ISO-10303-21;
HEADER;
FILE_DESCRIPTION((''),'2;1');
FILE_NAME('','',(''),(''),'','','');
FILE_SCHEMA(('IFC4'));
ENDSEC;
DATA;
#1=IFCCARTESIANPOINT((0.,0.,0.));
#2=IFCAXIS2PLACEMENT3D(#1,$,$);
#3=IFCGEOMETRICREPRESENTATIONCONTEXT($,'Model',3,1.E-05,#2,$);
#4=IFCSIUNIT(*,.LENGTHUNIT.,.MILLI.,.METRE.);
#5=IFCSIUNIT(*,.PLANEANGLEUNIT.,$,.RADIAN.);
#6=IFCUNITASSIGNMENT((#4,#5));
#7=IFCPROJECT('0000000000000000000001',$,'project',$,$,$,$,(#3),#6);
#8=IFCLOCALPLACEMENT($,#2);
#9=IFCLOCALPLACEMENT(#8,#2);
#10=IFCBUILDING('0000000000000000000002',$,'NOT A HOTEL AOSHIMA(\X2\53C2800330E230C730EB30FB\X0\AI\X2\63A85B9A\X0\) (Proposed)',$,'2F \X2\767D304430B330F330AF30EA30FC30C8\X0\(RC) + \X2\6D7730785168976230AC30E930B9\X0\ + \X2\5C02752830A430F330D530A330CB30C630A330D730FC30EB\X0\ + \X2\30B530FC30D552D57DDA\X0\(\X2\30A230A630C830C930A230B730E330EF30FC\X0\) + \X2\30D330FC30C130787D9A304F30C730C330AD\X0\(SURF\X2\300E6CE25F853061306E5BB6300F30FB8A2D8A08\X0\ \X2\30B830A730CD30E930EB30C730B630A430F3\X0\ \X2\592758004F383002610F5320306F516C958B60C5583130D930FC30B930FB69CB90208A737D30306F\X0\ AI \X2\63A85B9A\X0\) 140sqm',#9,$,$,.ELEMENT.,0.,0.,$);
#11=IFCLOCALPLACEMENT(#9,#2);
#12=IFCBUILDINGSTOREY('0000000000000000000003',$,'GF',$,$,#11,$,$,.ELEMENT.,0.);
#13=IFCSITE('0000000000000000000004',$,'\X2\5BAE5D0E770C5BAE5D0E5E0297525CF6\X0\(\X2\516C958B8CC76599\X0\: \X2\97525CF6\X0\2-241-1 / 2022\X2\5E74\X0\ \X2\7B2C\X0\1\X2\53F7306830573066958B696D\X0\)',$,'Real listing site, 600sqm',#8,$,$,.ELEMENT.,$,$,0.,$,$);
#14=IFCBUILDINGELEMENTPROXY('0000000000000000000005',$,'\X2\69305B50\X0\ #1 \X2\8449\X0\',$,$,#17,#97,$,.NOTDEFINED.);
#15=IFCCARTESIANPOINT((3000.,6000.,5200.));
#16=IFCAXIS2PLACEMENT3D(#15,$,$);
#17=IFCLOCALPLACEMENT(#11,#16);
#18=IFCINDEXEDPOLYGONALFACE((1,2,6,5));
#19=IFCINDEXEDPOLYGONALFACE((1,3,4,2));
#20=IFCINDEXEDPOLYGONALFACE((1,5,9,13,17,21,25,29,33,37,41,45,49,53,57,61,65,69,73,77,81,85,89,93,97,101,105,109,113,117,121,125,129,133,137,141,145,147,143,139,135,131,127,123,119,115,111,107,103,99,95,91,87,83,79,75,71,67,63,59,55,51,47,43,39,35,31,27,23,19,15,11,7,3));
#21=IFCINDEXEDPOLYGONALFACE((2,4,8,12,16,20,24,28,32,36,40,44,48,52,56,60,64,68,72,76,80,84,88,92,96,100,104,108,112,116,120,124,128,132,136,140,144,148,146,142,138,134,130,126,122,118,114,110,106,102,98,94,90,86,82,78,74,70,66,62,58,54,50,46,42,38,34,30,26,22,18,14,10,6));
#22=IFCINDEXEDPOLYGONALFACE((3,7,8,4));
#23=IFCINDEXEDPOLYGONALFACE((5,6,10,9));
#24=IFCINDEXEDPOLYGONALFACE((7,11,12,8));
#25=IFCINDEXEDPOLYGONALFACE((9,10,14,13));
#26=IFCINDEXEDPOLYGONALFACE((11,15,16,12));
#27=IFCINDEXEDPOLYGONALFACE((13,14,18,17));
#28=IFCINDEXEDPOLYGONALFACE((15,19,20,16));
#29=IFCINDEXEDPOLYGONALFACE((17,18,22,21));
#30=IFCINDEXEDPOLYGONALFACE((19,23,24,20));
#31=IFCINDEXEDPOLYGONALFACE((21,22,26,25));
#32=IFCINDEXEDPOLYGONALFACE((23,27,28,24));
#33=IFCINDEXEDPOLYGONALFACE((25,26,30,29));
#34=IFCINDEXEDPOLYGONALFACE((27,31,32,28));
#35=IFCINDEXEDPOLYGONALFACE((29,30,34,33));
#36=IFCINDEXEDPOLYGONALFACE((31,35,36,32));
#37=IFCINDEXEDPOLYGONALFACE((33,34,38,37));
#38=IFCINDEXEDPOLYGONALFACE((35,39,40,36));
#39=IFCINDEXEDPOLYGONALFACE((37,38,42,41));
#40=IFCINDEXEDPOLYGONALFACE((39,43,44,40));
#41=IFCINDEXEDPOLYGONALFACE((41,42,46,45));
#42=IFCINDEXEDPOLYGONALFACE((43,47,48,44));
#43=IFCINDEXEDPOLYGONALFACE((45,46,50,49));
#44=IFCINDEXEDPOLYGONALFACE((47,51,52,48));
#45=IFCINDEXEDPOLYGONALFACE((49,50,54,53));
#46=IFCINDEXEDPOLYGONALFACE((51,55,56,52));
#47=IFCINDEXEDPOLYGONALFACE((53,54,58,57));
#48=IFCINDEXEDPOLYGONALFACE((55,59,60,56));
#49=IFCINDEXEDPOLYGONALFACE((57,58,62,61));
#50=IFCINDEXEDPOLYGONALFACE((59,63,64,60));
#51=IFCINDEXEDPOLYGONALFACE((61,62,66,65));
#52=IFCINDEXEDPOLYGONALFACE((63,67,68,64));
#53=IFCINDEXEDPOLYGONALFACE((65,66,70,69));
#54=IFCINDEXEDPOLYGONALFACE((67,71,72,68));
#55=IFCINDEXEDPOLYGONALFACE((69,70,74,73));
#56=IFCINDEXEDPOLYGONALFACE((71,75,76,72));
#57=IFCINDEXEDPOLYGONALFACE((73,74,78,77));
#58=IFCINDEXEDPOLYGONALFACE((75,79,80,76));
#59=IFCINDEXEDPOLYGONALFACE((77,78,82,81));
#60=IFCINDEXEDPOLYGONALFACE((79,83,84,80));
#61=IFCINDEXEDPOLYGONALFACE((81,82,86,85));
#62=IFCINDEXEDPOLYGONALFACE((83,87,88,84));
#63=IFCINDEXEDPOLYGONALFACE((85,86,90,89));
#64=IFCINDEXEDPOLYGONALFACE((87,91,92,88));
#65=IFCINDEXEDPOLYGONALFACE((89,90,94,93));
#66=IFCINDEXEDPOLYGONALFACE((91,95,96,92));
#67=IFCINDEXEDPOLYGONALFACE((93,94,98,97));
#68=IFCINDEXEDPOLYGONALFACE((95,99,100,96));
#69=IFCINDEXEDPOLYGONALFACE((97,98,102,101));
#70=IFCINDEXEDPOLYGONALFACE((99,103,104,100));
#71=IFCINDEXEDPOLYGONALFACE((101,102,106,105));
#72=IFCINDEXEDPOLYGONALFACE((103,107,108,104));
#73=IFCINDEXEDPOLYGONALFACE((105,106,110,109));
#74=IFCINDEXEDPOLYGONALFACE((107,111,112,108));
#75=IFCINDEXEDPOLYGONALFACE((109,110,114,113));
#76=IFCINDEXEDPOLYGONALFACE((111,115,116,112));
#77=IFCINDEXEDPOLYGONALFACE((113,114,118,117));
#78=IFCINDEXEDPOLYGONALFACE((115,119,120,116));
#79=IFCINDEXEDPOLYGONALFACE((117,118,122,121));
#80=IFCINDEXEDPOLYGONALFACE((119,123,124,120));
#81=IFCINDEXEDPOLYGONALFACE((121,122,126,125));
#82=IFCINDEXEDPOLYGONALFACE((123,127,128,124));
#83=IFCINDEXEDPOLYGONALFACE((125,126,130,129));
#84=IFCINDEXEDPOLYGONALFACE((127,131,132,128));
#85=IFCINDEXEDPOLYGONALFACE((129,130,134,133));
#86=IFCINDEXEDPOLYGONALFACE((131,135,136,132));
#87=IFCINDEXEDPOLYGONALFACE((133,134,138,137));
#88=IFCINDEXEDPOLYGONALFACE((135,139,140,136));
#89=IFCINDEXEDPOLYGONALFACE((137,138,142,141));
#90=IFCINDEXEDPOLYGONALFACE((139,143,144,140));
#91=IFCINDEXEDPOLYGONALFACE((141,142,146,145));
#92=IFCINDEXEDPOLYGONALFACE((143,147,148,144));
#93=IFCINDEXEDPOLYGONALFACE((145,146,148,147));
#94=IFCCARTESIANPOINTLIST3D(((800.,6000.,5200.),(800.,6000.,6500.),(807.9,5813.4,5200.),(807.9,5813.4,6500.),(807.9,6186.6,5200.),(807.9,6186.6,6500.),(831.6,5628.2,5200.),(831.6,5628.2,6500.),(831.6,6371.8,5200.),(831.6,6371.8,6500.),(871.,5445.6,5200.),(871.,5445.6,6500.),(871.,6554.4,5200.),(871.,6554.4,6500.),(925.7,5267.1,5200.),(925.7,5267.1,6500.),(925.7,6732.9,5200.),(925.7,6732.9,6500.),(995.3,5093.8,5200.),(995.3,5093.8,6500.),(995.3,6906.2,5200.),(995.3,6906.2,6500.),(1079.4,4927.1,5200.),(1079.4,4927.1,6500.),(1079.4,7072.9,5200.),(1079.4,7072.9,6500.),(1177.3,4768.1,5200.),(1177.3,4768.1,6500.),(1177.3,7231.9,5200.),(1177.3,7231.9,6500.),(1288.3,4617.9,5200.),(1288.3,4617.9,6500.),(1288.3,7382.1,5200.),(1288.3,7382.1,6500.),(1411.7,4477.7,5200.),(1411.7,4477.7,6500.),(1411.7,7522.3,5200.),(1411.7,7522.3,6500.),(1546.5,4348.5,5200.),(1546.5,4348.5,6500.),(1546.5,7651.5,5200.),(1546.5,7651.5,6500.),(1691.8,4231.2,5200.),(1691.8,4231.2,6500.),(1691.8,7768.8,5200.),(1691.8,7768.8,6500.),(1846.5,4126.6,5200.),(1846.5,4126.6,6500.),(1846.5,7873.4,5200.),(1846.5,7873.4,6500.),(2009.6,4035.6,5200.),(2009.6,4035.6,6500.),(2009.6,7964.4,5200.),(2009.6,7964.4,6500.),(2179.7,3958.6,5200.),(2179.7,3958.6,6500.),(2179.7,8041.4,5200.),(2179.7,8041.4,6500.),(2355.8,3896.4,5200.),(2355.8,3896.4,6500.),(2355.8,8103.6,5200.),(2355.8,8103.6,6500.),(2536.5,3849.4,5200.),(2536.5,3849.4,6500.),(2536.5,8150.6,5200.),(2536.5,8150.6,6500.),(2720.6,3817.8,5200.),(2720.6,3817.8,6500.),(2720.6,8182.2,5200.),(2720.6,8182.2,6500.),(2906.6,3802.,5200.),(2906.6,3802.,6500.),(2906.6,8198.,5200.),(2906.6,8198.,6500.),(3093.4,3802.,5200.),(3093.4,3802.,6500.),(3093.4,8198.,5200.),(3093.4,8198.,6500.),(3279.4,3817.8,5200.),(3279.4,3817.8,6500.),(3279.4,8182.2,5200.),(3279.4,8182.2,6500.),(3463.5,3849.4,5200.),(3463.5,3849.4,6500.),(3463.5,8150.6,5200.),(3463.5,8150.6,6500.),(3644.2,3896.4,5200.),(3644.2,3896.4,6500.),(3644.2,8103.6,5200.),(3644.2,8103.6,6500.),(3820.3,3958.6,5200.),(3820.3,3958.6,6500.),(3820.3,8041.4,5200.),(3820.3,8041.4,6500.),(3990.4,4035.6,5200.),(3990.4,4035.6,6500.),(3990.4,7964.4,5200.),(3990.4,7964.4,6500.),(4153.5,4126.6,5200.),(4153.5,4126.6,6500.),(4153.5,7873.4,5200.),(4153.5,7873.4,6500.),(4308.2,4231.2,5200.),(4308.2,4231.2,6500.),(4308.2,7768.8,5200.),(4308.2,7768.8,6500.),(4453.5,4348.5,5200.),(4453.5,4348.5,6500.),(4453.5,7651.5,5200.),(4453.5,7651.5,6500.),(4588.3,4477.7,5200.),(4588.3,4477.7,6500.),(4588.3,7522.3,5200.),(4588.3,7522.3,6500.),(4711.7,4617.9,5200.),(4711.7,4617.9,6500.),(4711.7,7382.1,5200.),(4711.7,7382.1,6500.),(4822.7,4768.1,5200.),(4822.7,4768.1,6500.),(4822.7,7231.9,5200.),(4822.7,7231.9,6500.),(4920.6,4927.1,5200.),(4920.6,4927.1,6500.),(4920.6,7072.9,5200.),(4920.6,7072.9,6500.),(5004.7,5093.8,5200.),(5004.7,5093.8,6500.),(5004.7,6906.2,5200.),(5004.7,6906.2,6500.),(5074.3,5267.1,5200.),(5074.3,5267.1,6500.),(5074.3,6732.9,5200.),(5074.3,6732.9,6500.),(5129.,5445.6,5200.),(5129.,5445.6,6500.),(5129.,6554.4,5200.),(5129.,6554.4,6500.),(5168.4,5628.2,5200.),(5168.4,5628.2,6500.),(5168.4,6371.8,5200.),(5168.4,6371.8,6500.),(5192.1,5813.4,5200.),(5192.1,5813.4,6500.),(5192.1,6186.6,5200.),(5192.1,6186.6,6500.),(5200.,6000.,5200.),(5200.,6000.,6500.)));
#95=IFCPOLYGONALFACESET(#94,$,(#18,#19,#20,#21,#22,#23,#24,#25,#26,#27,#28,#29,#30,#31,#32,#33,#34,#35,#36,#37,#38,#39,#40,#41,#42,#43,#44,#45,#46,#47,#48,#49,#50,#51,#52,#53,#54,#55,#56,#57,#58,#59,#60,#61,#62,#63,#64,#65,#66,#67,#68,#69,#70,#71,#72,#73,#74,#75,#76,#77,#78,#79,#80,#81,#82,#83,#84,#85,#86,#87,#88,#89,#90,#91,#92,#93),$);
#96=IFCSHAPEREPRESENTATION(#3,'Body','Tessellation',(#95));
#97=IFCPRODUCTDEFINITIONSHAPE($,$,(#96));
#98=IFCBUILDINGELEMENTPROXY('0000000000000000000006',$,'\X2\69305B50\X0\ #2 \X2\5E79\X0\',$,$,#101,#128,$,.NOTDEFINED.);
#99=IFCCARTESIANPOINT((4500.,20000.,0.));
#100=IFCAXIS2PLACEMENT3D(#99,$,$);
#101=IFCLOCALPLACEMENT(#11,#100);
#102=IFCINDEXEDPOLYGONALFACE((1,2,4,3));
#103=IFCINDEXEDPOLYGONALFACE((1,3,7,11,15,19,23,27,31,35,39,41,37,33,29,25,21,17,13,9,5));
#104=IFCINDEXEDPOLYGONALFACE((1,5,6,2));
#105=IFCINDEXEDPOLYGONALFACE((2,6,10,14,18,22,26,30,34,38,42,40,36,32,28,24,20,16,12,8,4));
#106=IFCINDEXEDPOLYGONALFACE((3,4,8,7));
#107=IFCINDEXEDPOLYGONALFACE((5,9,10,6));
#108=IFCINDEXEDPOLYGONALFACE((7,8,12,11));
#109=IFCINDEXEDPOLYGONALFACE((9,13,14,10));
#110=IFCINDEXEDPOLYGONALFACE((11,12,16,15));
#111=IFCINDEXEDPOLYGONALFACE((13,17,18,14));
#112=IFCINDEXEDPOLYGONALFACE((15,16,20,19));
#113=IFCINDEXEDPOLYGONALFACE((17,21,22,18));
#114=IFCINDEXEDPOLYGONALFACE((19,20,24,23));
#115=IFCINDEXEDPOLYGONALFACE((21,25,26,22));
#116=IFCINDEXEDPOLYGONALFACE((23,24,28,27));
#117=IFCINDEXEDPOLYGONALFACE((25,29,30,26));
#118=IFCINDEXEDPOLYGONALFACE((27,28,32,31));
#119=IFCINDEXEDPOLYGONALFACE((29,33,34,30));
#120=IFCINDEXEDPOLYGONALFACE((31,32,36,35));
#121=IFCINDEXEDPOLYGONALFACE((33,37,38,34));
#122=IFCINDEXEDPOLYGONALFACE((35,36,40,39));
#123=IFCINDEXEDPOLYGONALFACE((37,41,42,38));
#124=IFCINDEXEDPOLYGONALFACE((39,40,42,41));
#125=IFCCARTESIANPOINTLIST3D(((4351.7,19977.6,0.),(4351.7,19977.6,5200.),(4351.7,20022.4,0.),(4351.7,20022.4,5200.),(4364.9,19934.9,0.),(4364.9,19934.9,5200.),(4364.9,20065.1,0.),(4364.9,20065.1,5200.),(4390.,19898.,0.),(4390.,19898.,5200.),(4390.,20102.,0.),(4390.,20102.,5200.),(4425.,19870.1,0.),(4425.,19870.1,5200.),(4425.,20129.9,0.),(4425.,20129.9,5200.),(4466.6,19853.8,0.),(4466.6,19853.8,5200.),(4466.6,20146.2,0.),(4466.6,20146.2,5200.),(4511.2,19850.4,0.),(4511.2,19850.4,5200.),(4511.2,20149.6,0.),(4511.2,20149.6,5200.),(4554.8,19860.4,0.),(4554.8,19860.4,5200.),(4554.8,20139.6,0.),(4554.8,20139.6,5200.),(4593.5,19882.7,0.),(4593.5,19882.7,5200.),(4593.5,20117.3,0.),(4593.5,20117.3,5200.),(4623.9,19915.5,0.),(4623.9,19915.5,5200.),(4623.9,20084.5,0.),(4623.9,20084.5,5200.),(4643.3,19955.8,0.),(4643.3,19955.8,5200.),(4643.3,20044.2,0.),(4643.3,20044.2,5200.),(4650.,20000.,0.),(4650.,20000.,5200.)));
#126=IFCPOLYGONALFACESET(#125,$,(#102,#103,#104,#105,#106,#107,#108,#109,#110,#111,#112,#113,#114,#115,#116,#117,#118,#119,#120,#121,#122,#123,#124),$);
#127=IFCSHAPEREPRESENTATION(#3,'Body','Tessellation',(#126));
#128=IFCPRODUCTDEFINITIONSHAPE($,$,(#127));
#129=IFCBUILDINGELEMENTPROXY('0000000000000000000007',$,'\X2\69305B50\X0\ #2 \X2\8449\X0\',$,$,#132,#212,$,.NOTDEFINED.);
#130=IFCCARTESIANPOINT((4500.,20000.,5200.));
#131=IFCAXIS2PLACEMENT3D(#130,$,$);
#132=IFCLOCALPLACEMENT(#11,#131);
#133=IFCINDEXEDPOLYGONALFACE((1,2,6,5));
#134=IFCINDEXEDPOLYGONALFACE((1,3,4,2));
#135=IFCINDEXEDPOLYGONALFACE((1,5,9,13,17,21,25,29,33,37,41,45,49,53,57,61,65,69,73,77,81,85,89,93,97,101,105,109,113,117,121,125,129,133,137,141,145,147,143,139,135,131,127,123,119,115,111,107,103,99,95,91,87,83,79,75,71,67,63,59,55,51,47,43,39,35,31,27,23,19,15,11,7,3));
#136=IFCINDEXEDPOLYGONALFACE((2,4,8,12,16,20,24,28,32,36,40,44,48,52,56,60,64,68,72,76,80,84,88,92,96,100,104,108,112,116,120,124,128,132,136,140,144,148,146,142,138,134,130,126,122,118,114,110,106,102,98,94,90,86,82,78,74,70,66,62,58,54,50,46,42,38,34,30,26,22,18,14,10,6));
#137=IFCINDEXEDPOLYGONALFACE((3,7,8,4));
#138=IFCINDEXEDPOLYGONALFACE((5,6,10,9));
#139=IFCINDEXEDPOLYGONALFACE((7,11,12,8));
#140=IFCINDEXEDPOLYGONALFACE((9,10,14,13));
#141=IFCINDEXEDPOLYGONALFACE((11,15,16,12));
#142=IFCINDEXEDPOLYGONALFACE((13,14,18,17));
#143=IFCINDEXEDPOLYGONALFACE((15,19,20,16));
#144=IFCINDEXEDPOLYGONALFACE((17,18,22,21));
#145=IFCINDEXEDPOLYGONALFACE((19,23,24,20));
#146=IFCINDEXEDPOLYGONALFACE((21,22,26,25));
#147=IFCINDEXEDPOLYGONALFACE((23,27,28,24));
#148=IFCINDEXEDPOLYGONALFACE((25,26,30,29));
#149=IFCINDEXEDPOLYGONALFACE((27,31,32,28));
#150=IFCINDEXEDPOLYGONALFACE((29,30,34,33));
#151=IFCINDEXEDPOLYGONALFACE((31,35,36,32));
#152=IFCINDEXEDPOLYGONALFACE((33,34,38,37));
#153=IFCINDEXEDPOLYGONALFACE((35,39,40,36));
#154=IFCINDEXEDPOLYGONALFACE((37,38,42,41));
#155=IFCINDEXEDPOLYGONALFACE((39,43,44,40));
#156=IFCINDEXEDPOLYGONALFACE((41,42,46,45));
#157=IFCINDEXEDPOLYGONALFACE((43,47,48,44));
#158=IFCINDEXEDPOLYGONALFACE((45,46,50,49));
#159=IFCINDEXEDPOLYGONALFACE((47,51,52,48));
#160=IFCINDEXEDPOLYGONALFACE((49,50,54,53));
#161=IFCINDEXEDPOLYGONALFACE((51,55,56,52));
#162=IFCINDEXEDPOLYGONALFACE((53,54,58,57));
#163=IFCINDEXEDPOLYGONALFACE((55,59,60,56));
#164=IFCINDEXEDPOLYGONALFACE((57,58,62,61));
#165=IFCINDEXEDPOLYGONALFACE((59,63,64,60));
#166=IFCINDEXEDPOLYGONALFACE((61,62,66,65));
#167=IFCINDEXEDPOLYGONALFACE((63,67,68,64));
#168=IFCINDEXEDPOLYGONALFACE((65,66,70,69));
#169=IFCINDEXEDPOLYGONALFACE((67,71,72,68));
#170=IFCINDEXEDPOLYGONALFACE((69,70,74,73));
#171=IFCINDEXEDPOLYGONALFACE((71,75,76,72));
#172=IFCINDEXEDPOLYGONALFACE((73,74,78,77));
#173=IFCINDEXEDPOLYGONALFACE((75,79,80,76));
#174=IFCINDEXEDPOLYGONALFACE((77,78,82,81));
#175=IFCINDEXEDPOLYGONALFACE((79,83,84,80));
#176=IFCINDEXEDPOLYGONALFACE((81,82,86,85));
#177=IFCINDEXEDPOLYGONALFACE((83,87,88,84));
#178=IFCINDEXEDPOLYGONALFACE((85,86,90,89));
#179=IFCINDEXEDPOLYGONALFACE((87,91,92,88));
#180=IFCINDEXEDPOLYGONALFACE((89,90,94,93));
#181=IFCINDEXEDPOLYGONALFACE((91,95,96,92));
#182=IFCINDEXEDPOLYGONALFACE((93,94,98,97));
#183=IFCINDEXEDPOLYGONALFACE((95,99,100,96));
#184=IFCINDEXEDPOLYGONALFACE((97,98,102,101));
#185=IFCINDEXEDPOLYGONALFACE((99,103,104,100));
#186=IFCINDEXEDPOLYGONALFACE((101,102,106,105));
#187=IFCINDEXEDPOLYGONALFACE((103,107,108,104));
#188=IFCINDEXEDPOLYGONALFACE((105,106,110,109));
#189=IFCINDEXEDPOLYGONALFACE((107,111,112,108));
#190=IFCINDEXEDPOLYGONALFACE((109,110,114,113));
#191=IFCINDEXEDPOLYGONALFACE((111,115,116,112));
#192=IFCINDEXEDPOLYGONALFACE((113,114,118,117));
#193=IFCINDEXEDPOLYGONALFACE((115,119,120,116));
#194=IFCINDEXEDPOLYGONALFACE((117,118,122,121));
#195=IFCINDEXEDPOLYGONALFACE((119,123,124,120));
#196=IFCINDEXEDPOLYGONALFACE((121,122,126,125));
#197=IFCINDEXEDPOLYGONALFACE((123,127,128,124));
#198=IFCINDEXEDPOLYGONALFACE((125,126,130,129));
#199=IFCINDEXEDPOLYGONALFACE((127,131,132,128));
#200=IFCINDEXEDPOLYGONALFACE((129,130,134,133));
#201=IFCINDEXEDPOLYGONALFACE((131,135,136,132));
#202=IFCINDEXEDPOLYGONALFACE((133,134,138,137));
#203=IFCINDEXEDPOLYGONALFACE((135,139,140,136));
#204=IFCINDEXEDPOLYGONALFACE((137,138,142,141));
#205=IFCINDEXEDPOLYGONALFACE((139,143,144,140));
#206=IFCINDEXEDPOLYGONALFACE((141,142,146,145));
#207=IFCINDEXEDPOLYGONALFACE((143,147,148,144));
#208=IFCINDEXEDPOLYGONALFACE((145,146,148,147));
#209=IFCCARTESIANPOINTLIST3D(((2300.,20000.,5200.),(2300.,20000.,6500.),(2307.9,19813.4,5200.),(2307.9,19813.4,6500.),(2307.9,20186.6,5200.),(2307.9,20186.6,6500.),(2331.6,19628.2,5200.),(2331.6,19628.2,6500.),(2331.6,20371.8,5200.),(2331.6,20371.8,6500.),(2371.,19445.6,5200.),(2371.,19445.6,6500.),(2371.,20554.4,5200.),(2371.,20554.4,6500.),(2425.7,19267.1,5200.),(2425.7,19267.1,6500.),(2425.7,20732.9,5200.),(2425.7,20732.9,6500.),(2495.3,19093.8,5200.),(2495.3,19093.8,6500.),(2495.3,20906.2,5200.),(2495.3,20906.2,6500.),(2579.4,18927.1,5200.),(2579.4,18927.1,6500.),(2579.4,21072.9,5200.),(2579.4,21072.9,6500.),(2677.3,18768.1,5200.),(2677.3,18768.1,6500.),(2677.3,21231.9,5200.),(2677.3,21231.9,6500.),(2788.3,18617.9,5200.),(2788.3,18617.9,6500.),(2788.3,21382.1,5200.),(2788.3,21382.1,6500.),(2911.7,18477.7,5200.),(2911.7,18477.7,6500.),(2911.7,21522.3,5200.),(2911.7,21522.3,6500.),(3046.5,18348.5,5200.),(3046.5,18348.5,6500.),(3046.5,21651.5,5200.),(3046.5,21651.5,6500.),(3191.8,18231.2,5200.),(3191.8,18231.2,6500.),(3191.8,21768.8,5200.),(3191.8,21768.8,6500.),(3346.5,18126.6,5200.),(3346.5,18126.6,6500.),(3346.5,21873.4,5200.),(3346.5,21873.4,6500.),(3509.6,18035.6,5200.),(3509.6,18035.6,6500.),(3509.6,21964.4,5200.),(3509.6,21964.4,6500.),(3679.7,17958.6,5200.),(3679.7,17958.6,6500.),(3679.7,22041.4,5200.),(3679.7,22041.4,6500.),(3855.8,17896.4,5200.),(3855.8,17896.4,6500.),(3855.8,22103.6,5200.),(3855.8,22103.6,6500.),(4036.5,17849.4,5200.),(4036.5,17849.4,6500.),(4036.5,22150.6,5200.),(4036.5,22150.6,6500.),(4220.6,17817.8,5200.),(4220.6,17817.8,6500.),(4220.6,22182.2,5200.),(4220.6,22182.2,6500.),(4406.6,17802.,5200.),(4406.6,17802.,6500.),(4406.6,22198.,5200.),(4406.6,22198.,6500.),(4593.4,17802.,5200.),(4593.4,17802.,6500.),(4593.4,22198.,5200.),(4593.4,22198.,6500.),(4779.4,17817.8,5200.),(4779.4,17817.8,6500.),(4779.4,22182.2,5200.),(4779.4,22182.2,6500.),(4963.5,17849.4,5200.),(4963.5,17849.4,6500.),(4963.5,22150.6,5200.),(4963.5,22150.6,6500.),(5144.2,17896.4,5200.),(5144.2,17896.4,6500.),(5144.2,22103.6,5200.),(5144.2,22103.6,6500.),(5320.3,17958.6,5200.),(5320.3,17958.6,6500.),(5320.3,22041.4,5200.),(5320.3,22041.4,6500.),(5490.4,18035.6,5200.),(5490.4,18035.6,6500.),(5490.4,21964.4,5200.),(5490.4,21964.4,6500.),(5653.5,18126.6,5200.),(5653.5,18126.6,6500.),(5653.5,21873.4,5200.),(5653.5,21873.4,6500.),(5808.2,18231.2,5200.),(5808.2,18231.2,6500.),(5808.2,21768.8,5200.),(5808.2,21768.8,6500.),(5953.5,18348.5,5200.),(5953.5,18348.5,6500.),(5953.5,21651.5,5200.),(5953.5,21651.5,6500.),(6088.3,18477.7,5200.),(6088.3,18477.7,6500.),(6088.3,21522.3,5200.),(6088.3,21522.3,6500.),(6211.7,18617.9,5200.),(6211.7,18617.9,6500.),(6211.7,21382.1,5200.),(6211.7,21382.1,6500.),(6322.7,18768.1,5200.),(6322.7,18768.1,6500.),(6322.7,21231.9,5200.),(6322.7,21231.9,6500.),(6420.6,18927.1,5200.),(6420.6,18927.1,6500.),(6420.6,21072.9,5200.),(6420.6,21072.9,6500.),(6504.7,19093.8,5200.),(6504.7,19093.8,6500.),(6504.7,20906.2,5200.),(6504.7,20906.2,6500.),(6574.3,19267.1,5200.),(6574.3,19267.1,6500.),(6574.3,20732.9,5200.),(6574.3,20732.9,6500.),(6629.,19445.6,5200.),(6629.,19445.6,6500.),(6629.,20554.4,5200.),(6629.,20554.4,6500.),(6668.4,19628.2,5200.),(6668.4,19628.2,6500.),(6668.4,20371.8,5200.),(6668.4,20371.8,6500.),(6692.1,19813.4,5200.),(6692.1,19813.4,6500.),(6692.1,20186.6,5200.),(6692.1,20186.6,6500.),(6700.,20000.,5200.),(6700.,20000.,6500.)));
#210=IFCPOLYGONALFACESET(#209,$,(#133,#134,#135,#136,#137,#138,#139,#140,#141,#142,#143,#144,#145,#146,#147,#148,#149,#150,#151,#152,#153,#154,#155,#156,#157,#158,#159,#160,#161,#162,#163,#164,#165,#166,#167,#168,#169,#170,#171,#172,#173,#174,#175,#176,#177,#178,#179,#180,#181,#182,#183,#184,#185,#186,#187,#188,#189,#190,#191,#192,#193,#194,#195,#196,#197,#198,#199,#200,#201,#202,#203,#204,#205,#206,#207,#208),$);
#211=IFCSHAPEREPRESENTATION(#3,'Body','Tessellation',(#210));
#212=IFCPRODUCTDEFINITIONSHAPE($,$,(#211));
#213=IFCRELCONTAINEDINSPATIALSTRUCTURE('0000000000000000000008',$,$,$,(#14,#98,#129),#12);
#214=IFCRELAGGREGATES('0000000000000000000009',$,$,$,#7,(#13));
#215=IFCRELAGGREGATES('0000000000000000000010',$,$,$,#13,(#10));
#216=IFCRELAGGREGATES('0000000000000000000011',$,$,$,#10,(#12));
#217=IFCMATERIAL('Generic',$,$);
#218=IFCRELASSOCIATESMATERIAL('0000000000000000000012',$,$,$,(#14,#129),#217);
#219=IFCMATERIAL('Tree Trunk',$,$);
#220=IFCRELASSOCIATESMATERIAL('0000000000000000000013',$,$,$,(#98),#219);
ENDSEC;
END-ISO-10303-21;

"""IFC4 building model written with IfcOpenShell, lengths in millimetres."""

from ifc_helpers import new_model, si_unit, frame, origin, origin_2d, place, context, project, spatial, circle, extrude, material, element, save


model = new_model("IFC4")

# Units and contexts
model_context = context("Model", 3, precision=1e-05, world=origin())
ifc_project = project(units=[si_unit("LENGTHUNIT", "METRE", prefix="MILLI"), si_unit("PLANEANGLEUNIT", "RADIAN")], contexts=[model_context])

# Site, building, storey
site_placement = place(None, origin())
site = spatial("IfcSite", under=ifc_project, at=site_placement, Name="宮崎県宮崎市青島(公開資料: 青島2-241-1 / 2022年 第1号として開業)", ObjectType="Real listing site, 600sqm", CompositionType="ELEMENT", RefElevation=0.0)
building_placement = place(site_placement, origin())
building = spatial("IfcBuilding", under=site, at=building_placement, Name="NOT A HOTEL AOSHIMA(参考モデル・AI推定) (Proposed)", ObjectType="2F 白いコンクリート(RC) + 海へ全面ガラス + 専用インフィニティプール + サーフ動線(アウトドアシャワー) + ビーチへ続くデッキ(SURF『波待ちの家』・設計 ジェネラルデザイン 大堀伸。意匠は公開情報ベース・構造詳細は AI 推定) 140sqm", CompositionType="ELEMENT", ElevationOfRefHeight=0.0, ElevationOfTerrain=0.0)
storey_placement = place(building_placement, origin())
storey = spatial("IfcBuildingStorey", under=building, at=storey_placement, Name="GF", CompositionType="ELEMENT", Elevation=0.0)

# Shared definitions
ifc_material_1 = material(Name="Generic")

# Building element proxies
ifc_material_2 = material(Name="Tree Trunk")
proxy_1_placement = place(storey_placement, frame((3000.0, 6000.0, 5200.0)))
element("IfcBuildingElementProxy", 1, at=proxy_1_placement, inside=storey, material=ifc_material_1, Name="椰子 #1 葉", PredefinedType="NOTDEFINED", context=model_context, shape_type="SweptSolid", body=[
    extrude(circle(Radius=2200.0, at=origin_2d()), frame((3000.0, 6000.0, 5200.0)), (0.0, 0.0, 1.0), 1300.0),
])
proxy_2_placement = place(storey_placement, frame((4500.0, 20000.0, 0.0)))
element("IfcBuildingElementProxy", 2, at=proxy_2_placement, inside=storey, material=ifc_material_2, Name="椰子 #2 幹", PredefinedType="NOTDEFINED", context=model_context, shape_type="SweptSolid", body=[
    extrude(circle(Radius=150.0, at=origin_2d()), frame((4500.0, 20000.0, 0.0)), (0.0, 0.0, 1.0), 5200.0),
])
proxy_3_placement = place(storey_placement, frame((4500.0, 20000.0, 5200.0)))
element("IfcBuildingElementProxy", 3, at=proxy_3_placement, inside=storey, material=ifc_material_1, Name="椰子 #2 葉", PredefinedType="NOTDEFINED", context=model_context, shape_type="SweptSolid", body=[
    extrude(circle(Radius=2200.0, at=origin_2d()), frame((4500.0, 20000.0, 5200.0)), (0.0, 0.0, 1.0), 1300.0),
])

save(model, "model.ifc")
